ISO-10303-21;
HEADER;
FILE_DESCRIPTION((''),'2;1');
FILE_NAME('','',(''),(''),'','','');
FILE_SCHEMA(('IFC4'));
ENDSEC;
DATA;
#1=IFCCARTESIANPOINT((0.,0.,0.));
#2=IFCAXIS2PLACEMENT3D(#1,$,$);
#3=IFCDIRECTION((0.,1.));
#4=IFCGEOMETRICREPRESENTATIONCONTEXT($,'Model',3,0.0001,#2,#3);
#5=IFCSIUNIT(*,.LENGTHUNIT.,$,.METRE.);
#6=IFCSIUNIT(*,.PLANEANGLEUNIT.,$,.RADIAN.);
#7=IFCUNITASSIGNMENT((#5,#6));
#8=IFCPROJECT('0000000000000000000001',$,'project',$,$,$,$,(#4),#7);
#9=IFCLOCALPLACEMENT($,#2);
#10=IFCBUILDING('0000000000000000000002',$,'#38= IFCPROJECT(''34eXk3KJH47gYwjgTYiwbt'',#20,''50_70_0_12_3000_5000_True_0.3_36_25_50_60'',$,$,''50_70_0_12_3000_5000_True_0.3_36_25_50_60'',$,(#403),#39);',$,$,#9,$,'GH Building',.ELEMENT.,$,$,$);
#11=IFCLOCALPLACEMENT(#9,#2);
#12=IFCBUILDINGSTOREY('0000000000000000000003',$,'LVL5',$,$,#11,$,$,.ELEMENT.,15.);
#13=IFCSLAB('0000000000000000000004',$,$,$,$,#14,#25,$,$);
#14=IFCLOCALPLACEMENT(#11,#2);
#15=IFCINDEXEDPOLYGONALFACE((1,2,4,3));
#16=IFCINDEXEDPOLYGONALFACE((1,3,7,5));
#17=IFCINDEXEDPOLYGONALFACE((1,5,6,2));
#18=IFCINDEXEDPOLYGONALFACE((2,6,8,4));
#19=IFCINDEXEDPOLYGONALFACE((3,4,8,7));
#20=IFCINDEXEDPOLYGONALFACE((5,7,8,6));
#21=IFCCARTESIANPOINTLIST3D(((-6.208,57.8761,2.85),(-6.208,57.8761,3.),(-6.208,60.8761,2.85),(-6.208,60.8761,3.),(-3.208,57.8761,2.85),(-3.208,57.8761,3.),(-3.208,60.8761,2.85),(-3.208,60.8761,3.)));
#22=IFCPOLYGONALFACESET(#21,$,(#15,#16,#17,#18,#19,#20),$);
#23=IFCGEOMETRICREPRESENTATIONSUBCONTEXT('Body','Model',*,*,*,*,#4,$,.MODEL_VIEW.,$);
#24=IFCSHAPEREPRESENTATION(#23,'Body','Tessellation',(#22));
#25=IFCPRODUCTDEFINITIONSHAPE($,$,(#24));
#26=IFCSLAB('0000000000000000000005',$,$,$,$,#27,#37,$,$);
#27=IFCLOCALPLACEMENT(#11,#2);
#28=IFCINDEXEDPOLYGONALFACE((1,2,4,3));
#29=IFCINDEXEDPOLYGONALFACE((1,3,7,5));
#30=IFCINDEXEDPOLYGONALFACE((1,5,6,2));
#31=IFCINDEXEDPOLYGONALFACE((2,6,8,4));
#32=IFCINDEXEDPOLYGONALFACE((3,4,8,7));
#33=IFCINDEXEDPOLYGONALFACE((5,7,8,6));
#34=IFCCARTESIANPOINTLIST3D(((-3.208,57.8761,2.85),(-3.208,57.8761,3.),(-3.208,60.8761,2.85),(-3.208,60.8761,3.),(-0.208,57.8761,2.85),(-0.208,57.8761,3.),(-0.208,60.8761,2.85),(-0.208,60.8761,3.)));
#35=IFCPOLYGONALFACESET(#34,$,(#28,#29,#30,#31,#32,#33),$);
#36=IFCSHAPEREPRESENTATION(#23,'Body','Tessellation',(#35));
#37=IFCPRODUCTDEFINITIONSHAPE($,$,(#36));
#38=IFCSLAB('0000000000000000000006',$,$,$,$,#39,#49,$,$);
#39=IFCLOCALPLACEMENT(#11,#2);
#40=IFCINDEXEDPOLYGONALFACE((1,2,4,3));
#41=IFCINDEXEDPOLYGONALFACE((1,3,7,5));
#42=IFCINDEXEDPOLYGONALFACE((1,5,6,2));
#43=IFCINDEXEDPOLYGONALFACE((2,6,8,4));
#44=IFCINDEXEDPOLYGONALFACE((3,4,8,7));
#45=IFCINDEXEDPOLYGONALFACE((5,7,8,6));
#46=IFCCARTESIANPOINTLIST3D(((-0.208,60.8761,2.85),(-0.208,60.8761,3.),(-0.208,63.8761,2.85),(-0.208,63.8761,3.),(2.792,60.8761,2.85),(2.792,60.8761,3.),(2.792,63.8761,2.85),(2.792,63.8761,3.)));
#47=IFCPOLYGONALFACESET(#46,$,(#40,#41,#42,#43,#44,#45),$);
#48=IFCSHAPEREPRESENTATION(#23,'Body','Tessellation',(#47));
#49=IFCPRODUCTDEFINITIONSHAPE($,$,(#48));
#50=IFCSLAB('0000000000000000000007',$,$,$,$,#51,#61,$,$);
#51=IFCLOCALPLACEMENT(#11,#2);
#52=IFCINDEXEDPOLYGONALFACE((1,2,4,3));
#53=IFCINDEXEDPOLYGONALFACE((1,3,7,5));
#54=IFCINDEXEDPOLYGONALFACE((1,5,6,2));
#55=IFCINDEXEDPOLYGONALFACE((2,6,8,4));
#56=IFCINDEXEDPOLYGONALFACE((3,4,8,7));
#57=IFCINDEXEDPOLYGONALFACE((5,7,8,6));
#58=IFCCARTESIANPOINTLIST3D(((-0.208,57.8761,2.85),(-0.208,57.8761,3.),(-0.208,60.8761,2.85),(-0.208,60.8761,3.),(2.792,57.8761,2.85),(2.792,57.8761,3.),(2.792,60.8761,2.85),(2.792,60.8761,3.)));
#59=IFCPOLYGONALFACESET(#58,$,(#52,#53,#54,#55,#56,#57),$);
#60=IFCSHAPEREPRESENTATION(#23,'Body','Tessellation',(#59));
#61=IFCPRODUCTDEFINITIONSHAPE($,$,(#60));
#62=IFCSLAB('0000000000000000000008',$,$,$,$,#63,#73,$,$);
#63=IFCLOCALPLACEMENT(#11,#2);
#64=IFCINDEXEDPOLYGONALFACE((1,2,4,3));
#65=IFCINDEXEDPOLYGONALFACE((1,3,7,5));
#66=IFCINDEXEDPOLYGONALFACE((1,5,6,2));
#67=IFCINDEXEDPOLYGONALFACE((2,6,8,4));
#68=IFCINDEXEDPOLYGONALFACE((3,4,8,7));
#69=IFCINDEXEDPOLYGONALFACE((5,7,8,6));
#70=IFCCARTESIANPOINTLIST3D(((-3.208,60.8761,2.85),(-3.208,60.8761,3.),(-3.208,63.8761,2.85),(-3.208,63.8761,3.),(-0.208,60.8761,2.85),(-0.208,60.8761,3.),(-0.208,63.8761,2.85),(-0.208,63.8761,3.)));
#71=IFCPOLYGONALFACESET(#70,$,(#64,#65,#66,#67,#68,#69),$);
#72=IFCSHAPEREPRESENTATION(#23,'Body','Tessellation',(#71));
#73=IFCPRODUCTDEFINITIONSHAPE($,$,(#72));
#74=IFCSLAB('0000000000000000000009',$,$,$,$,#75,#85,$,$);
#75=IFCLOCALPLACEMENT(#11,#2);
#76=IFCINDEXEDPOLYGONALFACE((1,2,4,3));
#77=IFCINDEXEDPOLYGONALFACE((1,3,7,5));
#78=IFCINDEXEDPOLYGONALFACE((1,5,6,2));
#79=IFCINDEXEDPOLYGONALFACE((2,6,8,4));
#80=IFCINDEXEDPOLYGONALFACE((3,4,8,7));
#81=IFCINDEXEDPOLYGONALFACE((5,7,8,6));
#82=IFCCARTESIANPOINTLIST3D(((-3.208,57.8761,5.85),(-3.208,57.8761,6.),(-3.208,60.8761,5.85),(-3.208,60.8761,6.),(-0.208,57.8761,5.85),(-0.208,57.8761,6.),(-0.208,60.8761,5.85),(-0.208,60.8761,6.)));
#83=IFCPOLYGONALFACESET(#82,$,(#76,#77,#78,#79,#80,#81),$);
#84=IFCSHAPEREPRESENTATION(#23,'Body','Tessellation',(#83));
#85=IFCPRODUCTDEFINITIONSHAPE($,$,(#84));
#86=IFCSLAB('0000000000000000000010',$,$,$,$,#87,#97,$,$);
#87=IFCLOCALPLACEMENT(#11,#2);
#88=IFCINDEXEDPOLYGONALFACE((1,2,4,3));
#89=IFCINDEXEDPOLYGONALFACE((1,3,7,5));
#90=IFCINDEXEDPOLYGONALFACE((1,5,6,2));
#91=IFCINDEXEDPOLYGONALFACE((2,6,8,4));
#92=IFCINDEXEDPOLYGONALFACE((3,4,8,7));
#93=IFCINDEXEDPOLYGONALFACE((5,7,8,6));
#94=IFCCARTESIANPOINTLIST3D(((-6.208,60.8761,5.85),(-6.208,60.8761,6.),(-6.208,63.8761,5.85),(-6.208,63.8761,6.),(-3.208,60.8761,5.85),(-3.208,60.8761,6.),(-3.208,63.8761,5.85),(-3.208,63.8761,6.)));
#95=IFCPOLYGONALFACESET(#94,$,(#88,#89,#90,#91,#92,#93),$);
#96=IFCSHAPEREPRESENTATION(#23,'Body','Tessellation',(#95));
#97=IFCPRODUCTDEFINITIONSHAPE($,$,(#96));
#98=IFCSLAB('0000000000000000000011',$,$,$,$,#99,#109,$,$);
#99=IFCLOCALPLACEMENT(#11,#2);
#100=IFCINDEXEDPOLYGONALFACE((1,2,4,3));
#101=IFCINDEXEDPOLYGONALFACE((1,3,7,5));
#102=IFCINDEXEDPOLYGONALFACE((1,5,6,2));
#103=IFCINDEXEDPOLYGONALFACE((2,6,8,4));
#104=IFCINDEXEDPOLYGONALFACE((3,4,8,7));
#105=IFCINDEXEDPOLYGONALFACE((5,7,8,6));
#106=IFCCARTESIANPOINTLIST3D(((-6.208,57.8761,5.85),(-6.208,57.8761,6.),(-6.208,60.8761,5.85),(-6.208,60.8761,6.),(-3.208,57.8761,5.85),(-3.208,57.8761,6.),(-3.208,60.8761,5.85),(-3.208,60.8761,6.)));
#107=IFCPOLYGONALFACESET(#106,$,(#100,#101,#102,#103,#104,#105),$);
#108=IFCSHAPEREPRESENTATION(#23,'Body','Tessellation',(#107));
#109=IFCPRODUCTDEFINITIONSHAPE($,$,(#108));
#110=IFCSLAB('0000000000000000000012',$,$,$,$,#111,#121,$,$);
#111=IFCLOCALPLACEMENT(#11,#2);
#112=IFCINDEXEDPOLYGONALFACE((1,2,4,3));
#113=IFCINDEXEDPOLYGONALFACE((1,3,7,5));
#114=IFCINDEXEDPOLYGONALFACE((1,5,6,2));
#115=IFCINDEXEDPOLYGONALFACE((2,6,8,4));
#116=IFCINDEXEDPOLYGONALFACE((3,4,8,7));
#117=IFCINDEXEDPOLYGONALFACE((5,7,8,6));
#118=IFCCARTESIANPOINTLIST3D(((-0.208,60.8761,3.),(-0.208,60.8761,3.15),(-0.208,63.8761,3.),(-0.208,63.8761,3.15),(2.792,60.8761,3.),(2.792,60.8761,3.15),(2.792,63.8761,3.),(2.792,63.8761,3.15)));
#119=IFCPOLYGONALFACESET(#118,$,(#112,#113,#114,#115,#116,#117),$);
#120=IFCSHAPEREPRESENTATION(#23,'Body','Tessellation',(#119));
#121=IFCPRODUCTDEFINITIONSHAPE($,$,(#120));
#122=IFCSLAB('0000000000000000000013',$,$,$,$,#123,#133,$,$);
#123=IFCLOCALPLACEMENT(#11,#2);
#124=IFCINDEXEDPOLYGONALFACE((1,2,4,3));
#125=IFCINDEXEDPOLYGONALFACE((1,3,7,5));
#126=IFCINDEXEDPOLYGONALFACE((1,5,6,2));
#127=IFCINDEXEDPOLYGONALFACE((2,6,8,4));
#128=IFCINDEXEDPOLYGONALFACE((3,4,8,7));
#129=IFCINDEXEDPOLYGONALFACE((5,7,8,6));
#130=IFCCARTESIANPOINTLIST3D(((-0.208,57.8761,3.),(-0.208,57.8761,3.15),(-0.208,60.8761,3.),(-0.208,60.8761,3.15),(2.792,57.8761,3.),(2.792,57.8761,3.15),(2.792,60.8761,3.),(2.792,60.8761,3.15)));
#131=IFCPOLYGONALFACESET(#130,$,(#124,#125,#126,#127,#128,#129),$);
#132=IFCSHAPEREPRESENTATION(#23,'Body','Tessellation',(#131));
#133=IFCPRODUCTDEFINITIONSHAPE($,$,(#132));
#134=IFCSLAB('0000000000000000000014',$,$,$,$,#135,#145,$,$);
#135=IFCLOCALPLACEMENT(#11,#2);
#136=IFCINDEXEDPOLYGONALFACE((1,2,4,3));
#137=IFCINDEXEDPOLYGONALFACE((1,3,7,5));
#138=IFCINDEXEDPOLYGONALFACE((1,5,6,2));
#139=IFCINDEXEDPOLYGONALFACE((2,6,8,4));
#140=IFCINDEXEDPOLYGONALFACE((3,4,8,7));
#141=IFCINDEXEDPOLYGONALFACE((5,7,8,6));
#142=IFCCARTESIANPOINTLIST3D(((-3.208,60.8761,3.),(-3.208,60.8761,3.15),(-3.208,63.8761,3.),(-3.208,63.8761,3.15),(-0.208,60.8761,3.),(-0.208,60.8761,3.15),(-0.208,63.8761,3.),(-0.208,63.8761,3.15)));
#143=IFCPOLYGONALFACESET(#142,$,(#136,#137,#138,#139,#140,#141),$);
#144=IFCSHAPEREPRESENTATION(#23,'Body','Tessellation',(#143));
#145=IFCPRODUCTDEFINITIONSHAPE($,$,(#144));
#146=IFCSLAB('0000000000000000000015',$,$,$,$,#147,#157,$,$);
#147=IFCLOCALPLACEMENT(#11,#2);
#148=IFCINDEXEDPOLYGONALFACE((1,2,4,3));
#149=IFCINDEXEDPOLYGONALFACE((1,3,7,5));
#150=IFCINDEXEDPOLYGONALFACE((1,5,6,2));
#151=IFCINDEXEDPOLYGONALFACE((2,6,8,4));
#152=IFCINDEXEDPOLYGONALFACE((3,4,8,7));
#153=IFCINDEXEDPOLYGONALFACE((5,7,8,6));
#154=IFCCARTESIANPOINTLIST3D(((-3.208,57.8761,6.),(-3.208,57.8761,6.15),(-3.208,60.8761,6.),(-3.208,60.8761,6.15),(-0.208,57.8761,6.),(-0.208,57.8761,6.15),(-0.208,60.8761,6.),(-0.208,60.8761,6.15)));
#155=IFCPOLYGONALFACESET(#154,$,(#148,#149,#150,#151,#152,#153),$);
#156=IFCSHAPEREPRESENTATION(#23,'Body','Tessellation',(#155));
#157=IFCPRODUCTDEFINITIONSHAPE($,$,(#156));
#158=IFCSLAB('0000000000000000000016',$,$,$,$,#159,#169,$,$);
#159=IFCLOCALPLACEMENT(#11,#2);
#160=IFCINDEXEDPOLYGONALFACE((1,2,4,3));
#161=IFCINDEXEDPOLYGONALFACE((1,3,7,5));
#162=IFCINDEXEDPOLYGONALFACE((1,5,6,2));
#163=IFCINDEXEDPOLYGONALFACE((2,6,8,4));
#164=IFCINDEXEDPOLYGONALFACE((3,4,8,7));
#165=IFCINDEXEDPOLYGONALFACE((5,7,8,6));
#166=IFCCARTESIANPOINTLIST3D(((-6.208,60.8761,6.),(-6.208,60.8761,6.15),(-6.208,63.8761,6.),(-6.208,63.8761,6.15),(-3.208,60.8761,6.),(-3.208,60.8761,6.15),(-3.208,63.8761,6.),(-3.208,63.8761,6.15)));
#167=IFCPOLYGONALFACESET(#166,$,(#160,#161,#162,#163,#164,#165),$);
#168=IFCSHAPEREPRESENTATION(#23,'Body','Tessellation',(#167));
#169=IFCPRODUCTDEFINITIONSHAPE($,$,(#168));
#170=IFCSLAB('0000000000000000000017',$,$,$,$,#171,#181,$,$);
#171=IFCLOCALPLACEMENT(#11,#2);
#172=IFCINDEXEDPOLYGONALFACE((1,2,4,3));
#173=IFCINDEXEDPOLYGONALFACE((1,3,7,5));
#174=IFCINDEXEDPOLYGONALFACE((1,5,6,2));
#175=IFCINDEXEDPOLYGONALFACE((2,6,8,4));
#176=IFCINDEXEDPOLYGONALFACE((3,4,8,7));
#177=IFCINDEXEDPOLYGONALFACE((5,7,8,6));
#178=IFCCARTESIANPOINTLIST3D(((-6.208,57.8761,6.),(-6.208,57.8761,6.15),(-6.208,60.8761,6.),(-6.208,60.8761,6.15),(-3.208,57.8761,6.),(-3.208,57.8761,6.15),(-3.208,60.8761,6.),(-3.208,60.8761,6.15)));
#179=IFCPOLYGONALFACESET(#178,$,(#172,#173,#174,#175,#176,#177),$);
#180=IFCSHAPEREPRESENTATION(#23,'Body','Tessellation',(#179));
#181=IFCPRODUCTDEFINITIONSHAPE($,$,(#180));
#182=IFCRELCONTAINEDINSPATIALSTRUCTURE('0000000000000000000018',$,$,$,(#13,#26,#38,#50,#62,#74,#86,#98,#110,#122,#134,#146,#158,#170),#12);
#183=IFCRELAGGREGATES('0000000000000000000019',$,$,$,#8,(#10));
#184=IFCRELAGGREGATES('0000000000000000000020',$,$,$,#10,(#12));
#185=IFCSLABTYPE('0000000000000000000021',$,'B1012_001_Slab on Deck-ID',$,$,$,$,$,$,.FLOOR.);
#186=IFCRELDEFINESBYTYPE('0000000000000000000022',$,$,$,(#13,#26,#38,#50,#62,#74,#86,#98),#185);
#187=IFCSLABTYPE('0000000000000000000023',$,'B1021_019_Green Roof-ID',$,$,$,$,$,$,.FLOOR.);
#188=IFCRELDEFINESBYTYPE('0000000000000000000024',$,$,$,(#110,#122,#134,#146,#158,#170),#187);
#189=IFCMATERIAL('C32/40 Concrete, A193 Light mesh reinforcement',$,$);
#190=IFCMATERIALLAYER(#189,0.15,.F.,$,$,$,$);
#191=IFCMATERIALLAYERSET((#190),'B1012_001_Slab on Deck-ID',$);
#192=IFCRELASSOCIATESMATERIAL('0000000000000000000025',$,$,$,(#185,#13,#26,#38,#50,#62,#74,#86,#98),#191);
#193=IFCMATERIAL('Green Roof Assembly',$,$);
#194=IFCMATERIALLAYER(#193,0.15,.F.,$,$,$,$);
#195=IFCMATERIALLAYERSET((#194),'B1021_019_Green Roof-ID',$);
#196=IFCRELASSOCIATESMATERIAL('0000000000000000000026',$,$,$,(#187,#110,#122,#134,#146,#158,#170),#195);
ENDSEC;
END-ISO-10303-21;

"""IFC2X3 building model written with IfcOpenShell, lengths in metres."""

from ifc_helpers import new_model, si_unit, direction, frame, origin, place, context, subcontext, project, spatial, polyline, outline, extrude, material, layer, layer_set, layer_usage, type_object, element, save


model = new_model("IFC2X3")

# Units and contexts
model_context = context("Model", 3, precision=0.0001, world=origin(), true_north=direction((0.0, 1.0)))
body_context = subcontext(model_context, "Body", "Model", "MODEL_VIEW")
ifc_project = project(units=[si_unit("LENGTHUNIT", "METRE"), si_unit("PLANEANGLEUNIT", "RADIAN")], contexts=[model_context])

# Building, storey
building_placement = place(None, origin())
building = spatial("IfcBuilding", under=ifc_project, at=building_placement, Name="#38= IFCPROJECT('34eXk3KJH47gYwjgTYiwbt',#20,'50_70_0_12_3000_5000_True_0.3_36_25_50_60',$,$,'50_70_0_12_3000_5000_True_0.3_36_25_50_60',$,(#403),#39);", LongName="GH Building", CompositionType="ELEMENT")
storey_placement = place(building_placement, origin())
storey = spatial("IfcBuildingStorey", under=building, at=storey_placement, Name="LVL5", CompositionType="ELEMENT", Elevation=15.0)

# Slabs
ifc_material_1 = material(Name="C32/40 Concrete, A193 Light mesh reinforcement")
ifc_layer_1 = layer(ifc_material_1, 0.15, ventilated=False)
ifc_layer_set_1 = layer_set([ifc_layer_1], Name="B1012_001_Slab on Deck-ID")
slab_type_1 = type_object("IfcSlabType", Name="B1012_001_Slab on Deck-ID", PredefinedType="FLOOR", material=ifc_layer_set_1)
ifc_layer_usage_1 = layer_usage(ifc_layer_set_1, "AXIS3", "NEGATIVE", -0.15)
slab_1_placement = place(storey_placement, frame((-4.708, 59.3761, 2.85)))
element("IfcSlab", 1, at=slab_1_placement, inside=storey, type_object=slab_type_1, material=ifc_layer_usage_1, context=body_context, shape_type="SweptSolid", body=[
    extrude(outline(polyline([(1.5, -1.5), (-1.5, -1.5), (-1.5, 1.5), (1.5, 1.5), (1.5, -1.5)])), origin(), (0.0, 0.0, 1.0), 0.15),
])
ifc_layer_usage_2 = layer_usage(ifc_layer_set_1, "AXIS3", "NEGATIVE", -0.15)
slab_2_placement = place(storey_placement, frame((-1.708, 59.3761, 2.85), z_axis=(0.0, 0.0, 1.0), x_axis=(0.0, 1.0, 0.0)))
element("IfcSlab", 2, at=slab_2_placement, inside=storey, type_object=slab_type_1, material=ifc_layer_usage_2, context=body_context, shape_type="SweptSolid", body=[
    extrude(outline(polyline([(-1.5, -1.5), (1.5, -1.5), (1.5, 1.5), (-1.5, 1.5), (-1.5, -1.5)])), origin(), (0.0, 0.0, 1.0), 0.15),
])
ifc_layer_usage_3 = layer_usage(ifc_layer_set_1, "AXIS3", "NEGATIVE", -0.15)
slab_3_placement = place(storey_placement, frame((1.292, 62.3761, 2.85), z_axis=(0.0, 0.0, 1.0), x_axis=(0.0, 1.0, 0.0)))
element("IfcSlab", 3, at=slab_3_placement, inside=storey, type_object=slab_type_1, material=ifc_layer_usage_3, context=body_context, shape_type="SweptSolid", body=[
    extrude(outline(polyline([(1.5, -1.5), (1.5, 1.5), (-1.5, 1.5), (-1.5, -1.5), (1.5, -1.5)])), origin(), (0.0, 0.0, 1.0), 0.15),
])
ifc_layer_usage_4 = layer_usage(ifc_layer_set_1, "AXIS3", "NEGATIVE", -0.15)
slab_4_placement = place(storey_placement, frame((1.292, 59.3761, 2.85), z_axis=(0.0, 0.0, 1.0), x_axis=(0.0, 1.0, 0.0)))
element("IfcSlab", 4, at=slab_4_placement, inside=storey, type_object=slab_type_1, material=ifc_layer_usage_4, context=body_context, shape_type="SweptSolid", body=[
    extrude(outline(polyline([(-1.5, -1.5), (1.5, -1.5), (1.5, 1.5), (-1.5, 1.5), (-1.5, -1.5)])), origin(), (0.0, 0.0, 1.0), 0.15),
])
ifc_layer_usage_5 = layer_usage(ifc_layer_set_1, "AXIS3", "NEGATIVE", -0.15)
slab_5_placement = place(storey_placement, frame((-1.708, 62.3761, 2.85), z_axis=(0.0, 0.0, 1.0), x_axis=(0.0, 1.0, 0.0)))
element("IfcSlab", 5, at=slab_5_placement, inside=storey, type_object=slab_type_1, material=ifc_layer_usage_5, context=body_context, shape_type="SweptSolid", body=[
    extrude(outline(polyline([(-1.5, -1.5), (1.5, -1.5), (1.5, 1.5), (-1.5, 1.5), (-1.5, -1.5)])), origin(), (0.0, 0.0, 1.0), 0.15),
])
ifc_layer_usage_6 = layer_usage(ifc_layer_set_1, "AXIS3", "NEGATIVE", -0.15)
slab_6_placement = place(storey_placement, frame((-1.708, 59.3761, 5.85)))
element("IfcSlab", 6, at=slab_6_placement, inside=storey, type_object=slab_type_1, material=ifc_layer_usage_6, context=body_context, shape_type="SweptSolid", body=[
    extrude(outline(polyline([(-1.5, -1.5), (-1.5, 1.5), (1.5, 1.5), (1.5, -1.5), (-1.5, -1.5)])), origin(), (0.0, 0.0, 1.0), 0.15),
])
ifc_layer_usage_7 = layer_usage(ifc_layer_set_1, "AXIS3", "NEGATIVE", -0.15)
slab_7_placement = place(storey_placement, frame((-4.708, 62.3761, 5.85)))
element("IfcSlab", 7, at=slab_7_placement, inside=storey, type_object=slab_type_1, material=ifc_layer_usage_7, context=body_context, shape_type="SweptSolid", body=[
    extrude(outline(polyline([(1.5, 1.5), (1.5, -1.5), (-1.5, -1.5), (-1.5, 1.5), (1.5, 1.5)])), origin(), (0.0, 0.0, 1.0), 0.15),
])
ifc_layer_usage_8 = layer_usage(ifc_layer_set_1, "AXIS3", "NEGATIVE", -0.15)
slab_8_placement = place(storey_placement, frame((-4.708, 59.3761, 5.85)))
element("IfcSlab", 8, at=slab_8_placement, inside=storey, type_object=slab_type_1, material=ifc_layer_usage_8, context=body_context, shape_type="SweptSolid", body=[
    extrude(outline(polyline([(1.5, -1.5), (-1.5, -1.5), (-1.5, 1.5), (1.5, 1.5), (1.5, -1.5)])), origin(), (0.0, 0.0, 1.0), 0.15),
])
ifc_material_2 = material(Name="Green Roof Assembly")
ifc_layer_2 = layer(ifc_material_2, 0.15, ventilated=False)
ifc_layer_set_2 = layer_set([ifc_layer_2], Name="B1021_019_Green Roof-ID")
ifc_layer_usage_9 = layer_usage(ifc_layer_set_2, "AXIS3", "NEGATIVE", -0.15)
slab_type_2 = type_object("IfcSlabType", Name="B1021_019_Green Roof-ID", PredefinedType="FLOOR", material=ifc_layer_set_2)
slab_9_placement = place(storey_placement, frame((1.292, 62.3761, 3.0), z_axis=(0.0, 0.0, 1.0), x_axis=(0.0, 1.0, 0.0)))
element("IfcSlab", 9, at=slab_9_placement, inside=storey, type_object=slab_type_2, material=ifc_layer_usage_9, context=body_context, shape_type="SweptSolid", body=[
    extrude(outline(polyline([(1.5, -1.5), (1.5, 1.5), (-1.5, 1.5), (-1.5, -1.5), (1.5, -1.5)])), origin(), (0.0, 0.0, 1.0), 0.15),
])
ifc_layer_usage_10 = layer_usage(ifc_layer_set_2, "AXIS3", "NEGATIVE", -0.15)
slab_10_placement = place(storey_placement, frame((1.292, 59.3761, 3.0), z_axis=(0.0, 0.0, 1.0), x_axis=(0.0, 1.0, 0.0)))
element("IfcSlab", 10, at=slab_10_placement, inside=storey, type_object=slab_type_2, material=ifc_layer_usage_10, context=body_context, shape_type="SweptSolid", body=[
    extrude(outline(polyline([(-1.5, -1.5), (1.5, -1.5), (1.5, 1.5), (-1.5, 1.5), (-1.5, -1.5)])), origin(), (0.0, 0.0, 1.0), 0.15),
])
ifc_layer_usage_11 = layer_usage(ifc_layer_set_2, "AXIS3", "NEGATIVE", -0.15)
slab_11_placement = place(storey_placement, frame((-1.708, 62.3761, 3.0), z_axis=(0.0, 0.0, 1.0), x_axis=(0.0, 1.0, 0.0)))
element("IfcSlab", 11, at=slab_11_placement, inside=storey, type_object=slab_type_2, material=ifc_layer_usage_11, context=body_context, shape_type="SweptSolid", body=[
    extrude(outline(polyline([(-1.5, -1.5), (1.5, -1.5), (1.5, 1.5), (-1.5, 1.5), (-1.5, -1.5)])), origin(), (0.0, 0.0, 1.0), 0.15),
])
ifc_layer_usage_12 = layer_usage(ifc_layer_set_2, "AXIS3", "NEGATIVE", -0.15)
slab_12_placement = place(storey_placement, frame((-1.708, 59.3761, 6.0)))
element("IfcSlab", 12, at=slab_12_placement, inside=storey, type_object=slab_type_2, material=ifc_layer_usage_12, context=body_context, shape_type="SweptSolid", body=[
    extrude(outline(polyline([(-1.5, -1.5), (-1.5, 1.5), (1.5, 1.5), (1.5, -1.5), (-1.5, -1.5)])), origin(), (0.0, 0.0, 1.0), 0.15),
])
ifc_layer_usage_13 = layer_usage(ifc_layer_set_2, "AXIS3", "NEGATIVE", -0.15)
slab_13_placement = place(storey_placement, frame((-4.708, 62.3761, 6.0)))
element("IfcSlab", 13, at=slab_13_placement, inside=storey, type_object=slab_type_2, material=ifc_layer_usage_13, context=body_context, shape_type="SweptSolid", body=[
    extrude(outline(polyline([(1.5, 1.5), (1.5, -1.5), (-1.5, -1.5), (-1.5, 1.5), (1.5, 1.5)])), origin(), (0.0, 0.0, 1.0), 0.15),
])
ifc_layer_usage_14 = layer_usage(ifc_layer_set_2, "AXIS3", "NEGATIVE", -0.15)
slab_14_placement = place(storey_placement, frame((-4.708, 59.3761, 6.0)))
element("IfcSlab", 14, at=slab_14_placement, inside=storey, type_object=slab_type_2, material=ifc_layer_usage_14, context=body_context, shape_type="SweptSolid", body=[
    extrude(outline(polyline([(1.5, -1.5), (-1.5, -1.5), (-1.5, 1.5), (1.5, 1.5), (1.5, -1.5)])), origin(), (0.0, 0.0, 1.0), 0.15),
])

save(model, "model.ifc")
